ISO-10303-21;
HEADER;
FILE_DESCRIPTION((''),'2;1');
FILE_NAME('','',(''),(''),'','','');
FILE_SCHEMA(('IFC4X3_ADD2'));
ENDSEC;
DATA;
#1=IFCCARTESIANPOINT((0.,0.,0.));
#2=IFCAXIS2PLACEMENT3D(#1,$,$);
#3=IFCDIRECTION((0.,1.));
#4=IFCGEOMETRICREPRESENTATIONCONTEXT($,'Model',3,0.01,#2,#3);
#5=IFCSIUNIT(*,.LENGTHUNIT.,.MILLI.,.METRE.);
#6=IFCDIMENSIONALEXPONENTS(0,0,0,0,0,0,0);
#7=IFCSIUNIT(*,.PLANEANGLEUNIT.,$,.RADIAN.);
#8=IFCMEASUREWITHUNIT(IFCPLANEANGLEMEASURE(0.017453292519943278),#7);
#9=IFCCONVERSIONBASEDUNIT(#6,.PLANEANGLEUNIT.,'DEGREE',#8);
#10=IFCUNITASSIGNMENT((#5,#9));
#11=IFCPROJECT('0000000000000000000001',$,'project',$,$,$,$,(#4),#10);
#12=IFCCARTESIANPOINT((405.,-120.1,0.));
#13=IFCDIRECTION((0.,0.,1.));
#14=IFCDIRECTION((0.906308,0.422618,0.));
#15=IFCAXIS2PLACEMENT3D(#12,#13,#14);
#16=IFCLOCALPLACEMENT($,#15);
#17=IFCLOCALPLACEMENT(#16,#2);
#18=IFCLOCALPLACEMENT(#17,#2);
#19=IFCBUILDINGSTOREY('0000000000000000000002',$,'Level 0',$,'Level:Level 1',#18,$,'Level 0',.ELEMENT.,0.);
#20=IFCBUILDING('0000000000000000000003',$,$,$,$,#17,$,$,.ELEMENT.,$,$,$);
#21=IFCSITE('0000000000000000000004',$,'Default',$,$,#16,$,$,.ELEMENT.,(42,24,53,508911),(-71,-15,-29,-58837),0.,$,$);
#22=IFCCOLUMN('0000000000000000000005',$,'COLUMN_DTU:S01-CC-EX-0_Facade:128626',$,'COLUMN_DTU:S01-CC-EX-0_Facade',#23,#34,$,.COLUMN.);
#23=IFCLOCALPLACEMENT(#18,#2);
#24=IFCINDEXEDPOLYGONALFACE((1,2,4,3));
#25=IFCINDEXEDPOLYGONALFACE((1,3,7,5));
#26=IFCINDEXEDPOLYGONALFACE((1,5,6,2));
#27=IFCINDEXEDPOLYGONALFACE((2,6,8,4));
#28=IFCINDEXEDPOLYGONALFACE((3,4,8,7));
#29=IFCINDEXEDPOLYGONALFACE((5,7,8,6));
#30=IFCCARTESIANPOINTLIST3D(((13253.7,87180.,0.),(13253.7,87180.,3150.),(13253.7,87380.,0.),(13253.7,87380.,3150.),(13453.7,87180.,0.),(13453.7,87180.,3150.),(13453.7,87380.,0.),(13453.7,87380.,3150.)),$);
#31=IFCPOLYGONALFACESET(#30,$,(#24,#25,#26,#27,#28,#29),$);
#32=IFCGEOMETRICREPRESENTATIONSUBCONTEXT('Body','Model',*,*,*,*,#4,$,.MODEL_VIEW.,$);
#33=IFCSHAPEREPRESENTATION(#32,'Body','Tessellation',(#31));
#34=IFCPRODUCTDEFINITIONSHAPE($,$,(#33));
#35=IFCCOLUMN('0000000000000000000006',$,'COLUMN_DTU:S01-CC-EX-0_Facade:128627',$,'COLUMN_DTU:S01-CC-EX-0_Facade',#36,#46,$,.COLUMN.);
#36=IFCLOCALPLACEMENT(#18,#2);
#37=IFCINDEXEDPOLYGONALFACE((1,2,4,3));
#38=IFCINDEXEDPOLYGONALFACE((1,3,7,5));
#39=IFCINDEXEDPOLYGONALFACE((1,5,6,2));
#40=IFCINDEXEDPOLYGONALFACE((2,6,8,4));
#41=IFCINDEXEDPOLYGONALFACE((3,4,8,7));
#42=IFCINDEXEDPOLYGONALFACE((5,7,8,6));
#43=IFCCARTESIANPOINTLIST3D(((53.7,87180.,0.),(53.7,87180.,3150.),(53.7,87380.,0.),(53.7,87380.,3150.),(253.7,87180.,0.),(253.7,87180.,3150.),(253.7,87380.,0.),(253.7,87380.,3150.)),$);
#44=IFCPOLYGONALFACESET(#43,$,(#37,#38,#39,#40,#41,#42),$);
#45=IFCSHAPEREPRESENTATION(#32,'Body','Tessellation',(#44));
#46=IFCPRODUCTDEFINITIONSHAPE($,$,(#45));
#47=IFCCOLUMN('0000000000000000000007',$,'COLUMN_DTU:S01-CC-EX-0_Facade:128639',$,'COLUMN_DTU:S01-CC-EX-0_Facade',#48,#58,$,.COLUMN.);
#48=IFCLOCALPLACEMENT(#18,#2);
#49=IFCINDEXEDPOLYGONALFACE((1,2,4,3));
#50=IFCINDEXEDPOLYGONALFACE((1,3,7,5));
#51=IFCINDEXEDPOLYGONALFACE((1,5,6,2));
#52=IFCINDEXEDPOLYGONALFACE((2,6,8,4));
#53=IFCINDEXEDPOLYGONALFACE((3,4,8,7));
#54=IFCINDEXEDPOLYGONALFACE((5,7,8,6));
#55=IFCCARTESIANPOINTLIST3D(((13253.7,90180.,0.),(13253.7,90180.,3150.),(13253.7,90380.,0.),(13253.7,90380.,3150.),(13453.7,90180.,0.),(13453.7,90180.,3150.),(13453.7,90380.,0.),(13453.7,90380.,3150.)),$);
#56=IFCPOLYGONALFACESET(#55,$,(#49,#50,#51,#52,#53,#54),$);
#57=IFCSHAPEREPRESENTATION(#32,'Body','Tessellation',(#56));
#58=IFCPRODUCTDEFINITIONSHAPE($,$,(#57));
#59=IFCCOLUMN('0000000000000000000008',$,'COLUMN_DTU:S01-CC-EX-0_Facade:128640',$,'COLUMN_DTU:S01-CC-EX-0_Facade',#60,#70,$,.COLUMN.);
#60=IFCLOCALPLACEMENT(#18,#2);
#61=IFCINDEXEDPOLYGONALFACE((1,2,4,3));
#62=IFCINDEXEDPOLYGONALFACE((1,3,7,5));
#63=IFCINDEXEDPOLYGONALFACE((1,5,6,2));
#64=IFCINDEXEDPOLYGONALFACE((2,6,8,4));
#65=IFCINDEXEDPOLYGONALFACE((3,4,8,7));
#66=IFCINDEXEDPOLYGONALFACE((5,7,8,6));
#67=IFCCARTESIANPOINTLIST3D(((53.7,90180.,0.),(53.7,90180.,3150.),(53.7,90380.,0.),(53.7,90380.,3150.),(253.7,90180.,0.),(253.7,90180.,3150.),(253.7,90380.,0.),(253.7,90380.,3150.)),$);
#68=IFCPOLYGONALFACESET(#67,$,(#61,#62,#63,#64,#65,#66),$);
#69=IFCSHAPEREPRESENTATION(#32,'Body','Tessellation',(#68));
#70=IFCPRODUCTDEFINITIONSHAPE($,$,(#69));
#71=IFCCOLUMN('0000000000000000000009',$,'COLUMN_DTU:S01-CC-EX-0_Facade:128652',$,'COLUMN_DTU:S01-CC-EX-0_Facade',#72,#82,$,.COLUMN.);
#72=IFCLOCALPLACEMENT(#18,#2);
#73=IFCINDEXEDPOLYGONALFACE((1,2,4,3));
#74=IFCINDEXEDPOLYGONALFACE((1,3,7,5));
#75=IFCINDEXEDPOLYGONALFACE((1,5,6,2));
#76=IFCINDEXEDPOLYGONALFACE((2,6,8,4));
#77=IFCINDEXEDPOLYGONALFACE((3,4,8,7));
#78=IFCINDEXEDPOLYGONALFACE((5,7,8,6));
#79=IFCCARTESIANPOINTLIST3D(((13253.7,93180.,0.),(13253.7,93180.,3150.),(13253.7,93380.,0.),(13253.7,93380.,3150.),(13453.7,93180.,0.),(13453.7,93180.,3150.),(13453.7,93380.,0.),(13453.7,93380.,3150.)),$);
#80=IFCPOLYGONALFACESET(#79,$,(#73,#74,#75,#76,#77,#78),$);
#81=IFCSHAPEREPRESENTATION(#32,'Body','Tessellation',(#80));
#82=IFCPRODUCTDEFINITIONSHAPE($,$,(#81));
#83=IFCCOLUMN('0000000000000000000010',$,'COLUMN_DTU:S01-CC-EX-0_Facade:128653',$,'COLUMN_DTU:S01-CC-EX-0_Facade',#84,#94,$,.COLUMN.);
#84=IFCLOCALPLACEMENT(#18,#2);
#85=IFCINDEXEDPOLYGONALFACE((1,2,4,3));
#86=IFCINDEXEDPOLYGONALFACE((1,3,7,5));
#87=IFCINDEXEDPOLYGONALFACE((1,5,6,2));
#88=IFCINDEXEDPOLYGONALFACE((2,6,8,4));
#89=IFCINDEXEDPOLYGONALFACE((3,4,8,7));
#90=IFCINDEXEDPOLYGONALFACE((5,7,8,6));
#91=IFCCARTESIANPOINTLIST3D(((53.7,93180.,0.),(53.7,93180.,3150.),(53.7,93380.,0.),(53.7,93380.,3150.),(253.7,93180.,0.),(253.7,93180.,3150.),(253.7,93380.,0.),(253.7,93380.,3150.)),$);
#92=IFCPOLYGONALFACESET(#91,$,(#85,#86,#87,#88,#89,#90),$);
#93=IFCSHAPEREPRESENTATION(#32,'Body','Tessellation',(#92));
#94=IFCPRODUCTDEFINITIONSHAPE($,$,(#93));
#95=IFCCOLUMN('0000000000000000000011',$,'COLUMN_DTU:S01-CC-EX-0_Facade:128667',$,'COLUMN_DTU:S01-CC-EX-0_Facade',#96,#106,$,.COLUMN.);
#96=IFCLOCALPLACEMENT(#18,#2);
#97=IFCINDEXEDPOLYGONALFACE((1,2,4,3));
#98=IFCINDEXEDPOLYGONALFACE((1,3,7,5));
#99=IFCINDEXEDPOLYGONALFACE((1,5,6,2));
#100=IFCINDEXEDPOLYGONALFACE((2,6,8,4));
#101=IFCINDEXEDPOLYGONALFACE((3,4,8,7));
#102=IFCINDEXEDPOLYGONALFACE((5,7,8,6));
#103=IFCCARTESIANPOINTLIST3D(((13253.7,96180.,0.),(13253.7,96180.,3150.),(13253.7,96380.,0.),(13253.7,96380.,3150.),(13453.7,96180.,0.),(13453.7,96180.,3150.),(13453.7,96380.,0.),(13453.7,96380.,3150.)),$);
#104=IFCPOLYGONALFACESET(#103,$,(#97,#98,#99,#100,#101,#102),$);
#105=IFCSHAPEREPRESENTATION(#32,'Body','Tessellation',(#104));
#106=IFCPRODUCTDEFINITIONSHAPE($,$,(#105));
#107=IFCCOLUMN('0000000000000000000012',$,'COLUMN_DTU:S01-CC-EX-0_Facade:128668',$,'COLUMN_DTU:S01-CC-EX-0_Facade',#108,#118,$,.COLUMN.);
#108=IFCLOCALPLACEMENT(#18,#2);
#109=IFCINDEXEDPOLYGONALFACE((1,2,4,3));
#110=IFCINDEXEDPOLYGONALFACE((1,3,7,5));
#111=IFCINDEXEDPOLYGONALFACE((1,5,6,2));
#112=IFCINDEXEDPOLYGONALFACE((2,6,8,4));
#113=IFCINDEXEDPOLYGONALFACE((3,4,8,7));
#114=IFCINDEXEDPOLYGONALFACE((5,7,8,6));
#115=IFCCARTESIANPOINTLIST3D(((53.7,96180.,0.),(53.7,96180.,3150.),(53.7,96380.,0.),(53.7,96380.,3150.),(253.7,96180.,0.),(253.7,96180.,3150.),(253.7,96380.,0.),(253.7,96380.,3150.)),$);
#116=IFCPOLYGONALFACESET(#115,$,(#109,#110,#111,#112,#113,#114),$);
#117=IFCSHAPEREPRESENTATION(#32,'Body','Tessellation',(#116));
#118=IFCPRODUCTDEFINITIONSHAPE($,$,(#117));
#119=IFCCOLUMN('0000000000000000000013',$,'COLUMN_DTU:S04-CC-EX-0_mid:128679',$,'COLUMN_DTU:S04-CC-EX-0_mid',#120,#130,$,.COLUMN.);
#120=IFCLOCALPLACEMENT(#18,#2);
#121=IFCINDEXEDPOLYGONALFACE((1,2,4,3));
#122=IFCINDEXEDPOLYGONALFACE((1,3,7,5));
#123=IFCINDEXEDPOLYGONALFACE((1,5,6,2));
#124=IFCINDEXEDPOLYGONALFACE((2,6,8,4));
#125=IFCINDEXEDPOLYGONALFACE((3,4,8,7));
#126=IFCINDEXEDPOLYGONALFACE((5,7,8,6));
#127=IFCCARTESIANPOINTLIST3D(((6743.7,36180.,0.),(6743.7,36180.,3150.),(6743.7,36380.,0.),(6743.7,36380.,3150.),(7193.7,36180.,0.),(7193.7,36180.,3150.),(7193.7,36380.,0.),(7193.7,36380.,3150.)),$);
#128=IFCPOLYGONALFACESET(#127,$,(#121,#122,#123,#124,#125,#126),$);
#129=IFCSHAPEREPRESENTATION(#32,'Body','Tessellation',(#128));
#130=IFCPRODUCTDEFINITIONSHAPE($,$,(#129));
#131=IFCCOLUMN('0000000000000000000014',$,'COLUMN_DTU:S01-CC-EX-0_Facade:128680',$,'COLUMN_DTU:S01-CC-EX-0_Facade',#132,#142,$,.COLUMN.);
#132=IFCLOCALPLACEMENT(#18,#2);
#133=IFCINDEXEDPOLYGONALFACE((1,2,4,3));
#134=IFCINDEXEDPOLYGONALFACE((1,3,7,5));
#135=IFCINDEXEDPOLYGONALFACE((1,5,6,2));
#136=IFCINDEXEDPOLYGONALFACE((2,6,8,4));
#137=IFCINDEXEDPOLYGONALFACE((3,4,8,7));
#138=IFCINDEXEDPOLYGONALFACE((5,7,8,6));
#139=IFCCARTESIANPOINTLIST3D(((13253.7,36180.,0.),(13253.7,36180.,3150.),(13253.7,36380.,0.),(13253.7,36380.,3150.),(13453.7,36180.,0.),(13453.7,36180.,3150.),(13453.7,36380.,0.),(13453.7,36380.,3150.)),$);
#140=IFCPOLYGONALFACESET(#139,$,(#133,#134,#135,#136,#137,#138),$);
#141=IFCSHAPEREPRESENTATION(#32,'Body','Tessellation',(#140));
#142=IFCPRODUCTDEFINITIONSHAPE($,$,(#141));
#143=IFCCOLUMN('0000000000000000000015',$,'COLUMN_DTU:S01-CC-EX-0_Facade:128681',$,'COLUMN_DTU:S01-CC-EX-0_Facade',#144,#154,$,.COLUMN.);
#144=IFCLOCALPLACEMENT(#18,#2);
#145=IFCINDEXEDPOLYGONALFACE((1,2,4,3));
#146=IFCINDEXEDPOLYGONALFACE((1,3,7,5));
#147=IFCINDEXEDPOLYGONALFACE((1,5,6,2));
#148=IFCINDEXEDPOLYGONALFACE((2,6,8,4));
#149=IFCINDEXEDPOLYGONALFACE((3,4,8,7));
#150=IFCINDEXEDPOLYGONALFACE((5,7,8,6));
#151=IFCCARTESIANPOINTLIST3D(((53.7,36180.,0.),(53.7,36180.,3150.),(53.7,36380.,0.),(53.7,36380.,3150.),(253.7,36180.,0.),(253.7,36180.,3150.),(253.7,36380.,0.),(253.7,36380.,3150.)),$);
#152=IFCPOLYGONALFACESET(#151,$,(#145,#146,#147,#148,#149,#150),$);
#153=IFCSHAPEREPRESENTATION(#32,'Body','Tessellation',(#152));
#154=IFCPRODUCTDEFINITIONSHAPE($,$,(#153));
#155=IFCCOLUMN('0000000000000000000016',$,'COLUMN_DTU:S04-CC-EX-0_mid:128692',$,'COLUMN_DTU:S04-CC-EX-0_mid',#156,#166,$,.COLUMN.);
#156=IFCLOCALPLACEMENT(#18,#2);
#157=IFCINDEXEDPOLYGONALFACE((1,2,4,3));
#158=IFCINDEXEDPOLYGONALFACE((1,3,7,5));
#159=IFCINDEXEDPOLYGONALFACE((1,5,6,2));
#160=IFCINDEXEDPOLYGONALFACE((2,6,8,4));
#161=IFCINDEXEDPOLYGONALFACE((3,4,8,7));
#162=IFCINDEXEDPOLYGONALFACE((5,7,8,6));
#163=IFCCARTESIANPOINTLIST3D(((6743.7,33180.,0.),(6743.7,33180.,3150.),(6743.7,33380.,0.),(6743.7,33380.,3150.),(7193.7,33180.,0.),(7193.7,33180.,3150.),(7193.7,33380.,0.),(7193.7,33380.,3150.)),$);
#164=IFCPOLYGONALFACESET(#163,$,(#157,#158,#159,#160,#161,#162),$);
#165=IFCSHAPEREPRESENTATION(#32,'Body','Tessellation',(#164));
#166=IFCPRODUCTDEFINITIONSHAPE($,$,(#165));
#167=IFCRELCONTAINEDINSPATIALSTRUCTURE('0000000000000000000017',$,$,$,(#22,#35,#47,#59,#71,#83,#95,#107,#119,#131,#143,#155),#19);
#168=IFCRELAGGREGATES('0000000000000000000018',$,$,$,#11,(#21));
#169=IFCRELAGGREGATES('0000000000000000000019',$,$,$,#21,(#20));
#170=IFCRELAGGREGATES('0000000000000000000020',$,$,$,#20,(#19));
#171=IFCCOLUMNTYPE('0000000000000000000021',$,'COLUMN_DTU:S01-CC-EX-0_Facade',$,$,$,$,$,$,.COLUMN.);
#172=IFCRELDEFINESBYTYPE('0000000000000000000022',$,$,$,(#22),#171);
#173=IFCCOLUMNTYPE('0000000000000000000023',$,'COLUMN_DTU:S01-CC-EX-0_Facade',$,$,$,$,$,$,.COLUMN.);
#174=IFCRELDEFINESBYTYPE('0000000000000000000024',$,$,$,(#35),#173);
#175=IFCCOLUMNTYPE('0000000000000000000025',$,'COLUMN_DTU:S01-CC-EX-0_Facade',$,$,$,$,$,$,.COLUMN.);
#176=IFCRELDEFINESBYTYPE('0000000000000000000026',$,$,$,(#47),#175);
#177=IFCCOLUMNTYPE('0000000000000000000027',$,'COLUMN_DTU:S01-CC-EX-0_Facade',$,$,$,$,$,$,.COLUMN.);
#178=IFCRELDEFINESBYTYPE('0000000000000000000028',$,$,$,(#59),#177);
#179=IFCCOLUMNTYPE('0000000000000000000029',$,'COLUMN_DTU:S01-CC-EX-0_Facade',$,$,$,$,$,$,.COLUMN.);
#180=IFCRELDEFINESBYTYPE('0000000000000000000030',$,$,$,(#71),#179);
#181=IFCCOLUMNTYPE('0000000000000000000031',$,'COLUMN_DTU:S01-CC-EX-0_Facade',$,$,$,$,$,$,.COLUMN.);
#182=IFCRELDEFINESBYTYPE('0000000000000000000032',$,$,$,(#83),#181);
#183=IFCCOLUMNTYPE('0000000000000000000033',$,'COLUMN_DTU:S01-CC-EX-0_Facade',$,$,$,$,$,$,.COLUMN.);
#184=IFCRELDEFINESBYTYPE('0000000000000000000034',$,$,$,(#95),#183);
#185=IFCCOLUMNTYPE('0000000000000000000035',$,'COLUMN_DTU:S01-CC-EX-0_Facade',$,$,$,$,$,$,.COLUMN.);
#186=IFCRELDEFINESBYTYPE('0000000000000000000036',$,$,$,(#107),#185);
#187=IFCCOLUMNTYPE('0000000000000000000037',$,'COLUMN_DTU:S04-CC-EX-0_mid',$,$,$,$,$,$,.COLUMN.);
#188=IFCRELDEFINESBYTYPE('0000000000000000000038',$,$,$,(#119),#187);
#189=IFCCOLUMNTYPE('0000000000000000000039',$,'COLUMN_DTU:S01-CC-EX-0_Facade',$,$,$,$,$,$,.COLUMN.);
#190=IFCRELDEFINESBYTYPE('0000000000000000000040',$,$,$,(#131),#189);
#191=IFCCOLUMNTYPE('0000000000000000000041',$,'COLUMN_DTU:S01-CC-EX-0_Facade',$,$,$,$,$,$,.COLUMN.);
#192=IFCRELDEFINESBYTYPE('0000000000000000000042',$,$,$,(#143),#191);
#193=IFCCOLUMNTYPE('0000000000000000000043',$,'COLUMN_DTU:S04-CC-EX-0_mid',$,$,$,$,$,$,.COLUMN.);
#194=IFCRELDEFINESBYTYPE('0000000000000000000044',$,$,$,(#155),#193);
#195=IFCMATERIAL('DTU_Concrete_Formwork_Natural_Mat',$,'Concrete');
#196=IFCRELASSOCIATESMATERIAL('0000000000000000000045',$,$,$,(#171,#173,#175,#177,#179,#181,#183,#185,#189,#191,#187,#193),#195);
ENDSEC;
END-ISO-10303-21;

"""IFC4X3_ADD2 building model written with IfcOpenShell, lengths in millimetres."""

from ifc_helpers import new_model, entity, si_unit, converted_unit, direction, frame, frame_2d, origin, origin_2d_with_axis, place, context, subcontext, project, spatial, rectangle, extrude, source, transform, mapped, material, material_profile, profile_set, type_object, type_shapes, element, save


model = new_model("IFC4X3_ADD2")

# Units and contexts
model_context = context("Model", 3, precision=0.01, world=origin(), true_north=direction((0.0, 1.0)))
body_context = subcontext(model_context, "Body", "Model", "MODEL_VIEW")
ifc_project = project(units=[si_unit("LENGTHUNIT", "METRE", prefix="MILLI"), converted_unit("PLANEANGLEUNIT", "DEGREE", entity("IfcPlaneAngleMeasure", 0.017453292519943278), si_unit("PLANEANGLEUNIT", "RADIAN"), dimensions=[0, 0, 0, 0, 0, 0, 0])], contexts=[model_context])

# Site, building, storey
site_placement = place(None, frame((405.0, -120.1, 0.0), z_axis=(0.0, 0.0, 1.0), x_axis=(0.906308, 0.422618, 0.0)))
site = spatial("IfcSite", under=ifc_project, at=site_placement, Name="Default", CompositionType="ELEMENT", RefLatitude=(42, 24, 53, 508911), RefLongitude=(-71, -15, -29, -58837), RefElevation=0.0)
building_placement = place(site_placement, origin())
building = spatial("IfcBuilding", under=site, at=building_placement, CompositionType="ELEMENT")
storey_placement = place(building_placement, origin())
storey = spatial("IfcBuildingStorey", under=building, at=storey_placement, Name="Level 0", ObjectType="Level:Level 1", LongName="Level 0", CompositionType="ELEMENT", Elevation=0.0)

# Columns
ifc_material = material(Name="DTU_Concrete_Formwork_Natural_Mat", Category="Concrete")
ifc_material_profile_1 = material_profile(ifc_material, rectangle(XDim=200.0, YDim=200.0, at=frame_2d((0.0, 0.0), x_axis=(1.0, 0.0))), Name="S01-CC-EX-0_Facade")
ifc_profile_set_1 = profile_set([ifc_material_profile_1], Name="S01-CC-EX-0_Facade")
column_type_1 = type_object("IfcColumnType", Name="COLUMN_DTU:S01-CC-EX-0_Facade", PredefinedType="COLUMN", material=ifc_profile_set_1)
shared_shape_1 = source(origin(), body_context, "Body", "SweptSolid", [
    extrude(rectangle(XDim=200.0, YDim=200.0, at=frame_2d((0.0, 0.0), x_axis=(1.0, 0.0))), frame((13353.7, 87280.0, 0.0), z_axis=(0.0, 0.0, 1.0), x_axis=(0.0, 1.0, 0.0)), (0.0, 0.0, 1.0), 3150.0),
])
type_shapes(column_type_1, [shared_shape_1])
column_1_placement = place(storey_placement, origin())
element("IfcColumn", 1, at=column_1_placement, inside=storey, type_object=column_type_1, Name="COLUMN_DTU:S01-CC-EX-0_Facade:128626", ObjectType="COLUMN_DTU:S01-CC-EX-0_Facade", PredefinedType="COLUMN", context=body_context, shape_type="MappedRepresentation", body=[
    mapped(shared_shape_1, transform((0.0, 0.0, 0.0), scale=1.0)),
])
column_type_2 = type_object("IfcColumnType", Name="COLUMN_DTU:S01-CC-EX-0_Facade", PredefinedType="COLUMN", material=ifc_profile_set_1)
shared_shape_2 = source(origin(), body_context, "Body", "SweptSolid", [
    extrude(rectangle(XDim=200.0, YDim=200.0, at=frame_2d((0.0, 0.0), x_axis=(1.0, 0.0))), frame((153.7, 87280.0, 0.0), z_axis=(0.0, 0.0, 1.0), x_axis=(0.0, 1.0, 0.0)), (0.0, 0.0, 1.0), 3150.0),
])
type_shapes(column_type_2, [shared_shape_2])
column_2_placement = place(storey_placement, origin())
element("IfcColumn", 2, at=column_2_placement, inside=storey, type_object=column_type_2, Name="COLUMN_DTU:S01-CC-EX-0_Facade:128627", ObjectType="COLUMN_DTU:S01-CC-EX-0_Facade", PredefinedType="COLUMN", context=body_context, shape_type="MappedRepresentation", body=[
    mapped(shared_shape_2, transform((0.0, 0.0, 0.0), scale=1.0)),
])
column_type_3 = type_object("IfcColumnType", Name="COLUMN_DTU:S01-CC-EX-0_Facade", PredefinedType="COLUMN", material=ifc_profile_set_1)
shared_shape_3 = source(origin(), body_context, "Body", "SweptSolid", [
    extrude(rectangle(XDim=200.0, YDim=200.0, at=frame_2d((0.0, 0.0), x_axis=(1.0, 0.0))), frame((13353.7, 90280.0, 0.0), z_axis=(0.0, 0.0, 1.0), x_axis=(0.0, 1.0, 0.0)), (0.0, 0.0, 1.0), 3150.0),
])
type_shapes(column_type_3, [shared_shape_3])
column_3_placement = place(storey_placement, origin())
element("IfcColumn", 3, at=column_3_placement, inside=storey, type_object=column_type_3, Name="COLUMN_DTU:S01-CC-EX-0_Facade:128639", ObjectType="COLUMN_DTU:S01-CC-EX-0_Facade", PredefinedType="COLUMN", context=body_context, shape_type="MappedRepresentation", body=[
    mapped(shared_shape_3, transform((0.0, 0.0, 0.0), scale=1.0)),
])
column_type_4 = type_object("IfcColumnType", Name="COLUMN_DTU:S01-CC-EX-0_Facade", PredefinedType="COLUMN", material=ifc_profile_set_1)
shared_shape_4 = source(origin(), body_context, "Body", "SweptSolid", [
    extrude(rectangle(XDim=200.0, YDim=200.0, at=frame_2d((0.0, 0.0), x_axis=(1.0, 0.0))), frame((153.7, 90280.0, 0.0), z_axis=(0.0, 0.0, 1.0), x_axis=(0.0, 1.0, 0.0)), (0.0, 0.0, 1.0), 3150.0),
])
type_shapes(column_type_4, [shared_shape_4])
column_4_placement = place(storey_placement, origin())
element("IfcColumn", 4, at=column_4_placement, inside=storey, type_object=column_type_4, Name="COLUMN_DTU:S01-CC-EX-0_Facade:128640", ObjectType="COLUMN_DTU:S01-CC-EX-0_Facade", PredefinedType="COLUMN", context=body_context, shape_type="MappedRepresentation", body=[
    mapped(shared_shape_4, transform((0.0, 0.0, 0.0), scale=1.0)),
])
column_type_5 = type_object("IfcColumnType", Name="COLUMN_DTU:S01-CC-EX-0_Facade", PredefinedType="COLUMN", material=ifc_profile_set_1)
shared_shape_5 = source(origin(), body_context, "Body", "SweptSolid", [
    extrude(rectangle(XDim=200.0, YDim=200.0, at=frame_2d((0.0, 0.0), x_axis=(1.0, 0.0))), frame((13353.7, 93280.0, 0.0), z_axis=(0.0, 0.0, 1.0), x_axis=(0.0, 1.0, 0.0)), (0.0, 0.0, 1.0), 3150.0),
])
type_shapes(column_type_5, [shared_shape_5])
column_5_placement = place(storey_placement, origin())
element("IfcColumn", 5, at=column_5_placement, inside=storey, type_object=column_type_5, Name="COLUMN_DTU:S01-CC-EX-0_Facade:128652", ObjectType="COLUMN_DTU:S01-CC-EX-0_Facade", PredefinedType="COLUMN", context=body_context, shape_type="MappedRepresentation", body=[
    mapped(shared_shape_5, transform((0.0, 0.0, 0.0), scale=1.0)),
])
column_type_6 = type_object("IfcColumnType", Name="COLUMN_DTU:S01-CC-EX-0_Facade", PredefinedType="COLUMN", material=ifc_profile_set_1)
shared_shape_6 = source(origin(), body_context, "Body", "SweptSolid", [
    extrude(rectangle(XDim=200.0, YDim=200.0, at=frame_2d((0.0, 0.0), x_axis=(1.0, 0.0))), frame((153.7, 93280.0, 0.0), z_axis=(0.0, 0.0, 1.0), x_axis=(0.0, 1.0, 0.0)), (0.0, 0.0, 1.0), 3150.0),
])
type_shapes(column_type_6, [shared_shape_6])
column_6_placement = place(storey_placement, origin())
element("IfcColumn", 6, at=column_6_placement, inside=storey, type_object=column_type_6, Name="COLUMN_DTU:S01-CC-EX-0_Facade:128653", ObjectType="COLUMN_DTU:S01-CC-EX-0_Facade", PredefinedType="COLUMN", context=body_context, shape_type="MappedRepresentation", body=[
    mapped(shared_shape_6, transform((0.0, 0.0, 0.0), scale=1.0)),
])
column_type_7 = type_object("IfcColumnType", Name="COLUMN_DTU:S01-CC-EX-0_Facade", PredefinedType="COLUMN", material=ifc_profile_set_1)
shared_shape_7 = source(origin(), body_context, "Body", "SweptSolid", [
    extrude(rectangle(XDim=200.0, YDim=200.0, at=frame_2d((0.0, 0.0), x_axis=(1.0, 0.0))), frame((13353.7, 96280.0, 0.0), z_axis=(0.0, 0.0, 1.0), x_axis=(0.0, 1.0, 0.0)), (0.0, 0.0, 1.0), 3150.0),
])
type_shapes(column_type_7, [shared_shape_7])
column_7_placement = place(storey_placement, origin())
element("IfcColumn", 7, at=column_7_placement, inside=storey, type_object=column_type_7, Name="COLUMN_DTU:S01-CC-EX-0_Facade:128667", ObjectType="COLUMN_DTU:S01-CC-EX-0_Facade", PredefinedType="COLUMN", context=body_context, shape_type="MappedRepresentation", body=[
    mapped(shared_shape_7, transform((0.0, 0.0, 0.0), scale=1.0)),
])
column_type_8 = type_object("IfcColumnType", Name="COLUMN_DTU:S01-CC-EX-0_Facade", PredefinedType="COLUMN", material=ifc_profile_set_1)
shared_shape_8 = source(origin(), body_context, "Body", "SweptSolid", [
    extrude(rectangle(XDim=200.0, YDim=200.0, at=frame_2d((0.0, 0.0), x_axis=(1.0, 0.0))), frame((153.7, 96280.0, 0.0), z_axis=(0.0, 0.0, 1.0), x_axis=(0.0, 1.0, 0.0)), (0.0, 0.0, 1.0), 3150.0),
])
type_shapes(column_type_8, [shared_shape_8])
column_8_placement = place(storey_placement, origin())
element("IfcColumn", 8, at=column_8_placement, inside=storey, type_object=column_type_8, Name="COLUMN_DTU:S01-CC-EX-0_Facade:128668", ObjectType="COLUMN_DTU:S01-CC-EX-0_Facade", PredefinedType="COLUMN", context=body_context, shape_type="MappedRepresentation", body=[
    mapped(shared_shape_8, transform((0.0, 0.0, 0.0), scale=1.0)),
])
ifc_material_profile_2 = material_profile(ifc_material, rectangle(XDim=200.0, YDim=450.0, at=frame_2d((0.0, 0.0), x_axis=(1.0, 0.0))), Name="S04-CC-EX-0_mid")
ifc_profile_set_2 = profile_set([ifc_material_profile_2], Name="S04-CC-EX-0_mid")
column_type_9 = type_object("IfcColumnType", Name="COLUMN_DTU:S04-CC-EX-0_mid", PredefinedType="COLUMN", material=ifc_profile_set_2)
shared_shape_9 = source(origin(), body_context, "Body", "SweptSolid", [
    extrude(rectangle(XDim=200.0, YDim=450.0, at=frame_2d((0.0, 0.0), x_axis=(1.0, 0.0))), frame((6968.7, 36280.0, 0.0), z_axis=(0.0, 0.0, 1.0), x_axis=(0.0, 1.0, 0.0)), (0.0, 0.0, 1.0), 3150.0),
])
type_shapes(column_type_9, [shared_shape_9])
column_9_placement = place(storey_placement, origin())
element("IfcColumn", 9, at=column_9_placement, inside=storey, type_object=column_type_9, Name="COLUMN_DTU:S04-CC-EX-0_mid:128679", ObjectType="COLUMN_DTU:S04-CC-EX-0_mid", PredefinedType="COLUMN", context=body_context, shape_type="MappedRepresentation", body=[
    mapped(shared_shape_9, transform((0.0, 0.0, 0.0), scale=1.0)),
])
column_type_10 = type_object("IfcColumnType", Name="COLUMN_DTU:S01-CC-EX-0_Facade", PredefinedType="COLUMN", material=ifc_profile_set_1)
shared_shape_10 = source(origin(), body_context, "Body", "SweptSolid", [
    extrude(rectangle(XDim=200.0, YDim=200.0, at=frame_2d((0.0, 0.0), x_axis=(1.0, 0.0))), frame((13353.7, 36280.0, 0.0), z_axis=(0.0, 0.0, 1.0), x_axis=(0.0, 1.0, 0.0)), (0.0, 0.0, 1.0), 3150.0),
])
type_shapes(column_type_10, [shared_shape_10])
column_10_placement = place(storey_placement, origin())
element("IfcColumn", 10, at=column_10_placement, inside=storey, type_object=column_type_10, Name="COLUMN_DTU:S01-CC-EX-0_Facade:128680", ObjectType="COLUMN_DTU:S01-CC-EX-0_Facade", PredefinedType="COLUMN", context=body_context, shape_type="MappedRepresentation", body=[
    mapped(shared_shape_10, transform((0.0, 0.0, 0.0), scale=1.0)),
])
column_type_11 = type_object("IfcColumnType", Name="COLUMN_DTU:S01-CC-EX-0_Facade", PredefinedType="COLUMN", material=ifc_profile_set_1)
shared_shape_11 = source(origin(), body_context, "Body", "SweptSolid", [
    extrude(rectangle(XDim=200.0, YDim=200.0, at=frame_2d((0.0, 0.0), x_axis=(1.0, 0.0))), frame((153.7, 36280.0, 0.0), z_axis=(0.0, 0.0, 1.0), x_axis=(0.0, 1.0, 0.0)), (0.0, 0.0, 1.0), 3150.0),
])
type_shapes(column_type_11, [shared_shape_11])
column_11_placement = place(storey_placement, origin())
element("IfcColumn", 11, at=column_11_placement, inside=storey, type_object=column_type_11, Name="COLUMN_DTU:S01-CC-EX-0_Facade:128681", ObjectType="COLUMN_DTU:S01-CC-EX-0_Facade", PredefinedType="COLUMN", context=body_context, shape_type="MappedRepresentation", body=[
    mapped(shared_shape_11, transform((0.0, 0.0, 0.0), scale=1.0)),
])
column_type_12 = type_object("IfcColumnType", Name="COLUMN_DTU:S04-CC-EX-0_mid", PredefinedType="COLUMN", material=ifc_profile_set_2)
shared_shape_12 = source(origin(), body_context, "Body", "SweptSolid", [
    extrude(rectangle(XDim=200.0, YDim=450.0, at=origin_2d_with_axis()), frame((6968.7, 33280.0, 0.0), z_axis=(0.0, 0.0, 1.0), x_axis=(0.0, 1.0, 0.0)), (0.0, 0.0, 1.0), 3150.0),
])
type_shapes(column_type_12, [shared_shape_12])
column_12_placement = place(storey_placement, origin())
element("IfcColumn", 12, at=column_12_placement, inside=storey, type_object=column_type_12, Name="COLUMN_DTU:S04-CC-EX-0_mid:128692", ObjectType="COLUMN_DTU:S04-CC-EX-0_mid", PredefinedType="COLUMN", context=body_context, shape_type="MappedRepresentation", body=[
    mapped(shared_shape_12, transform((0.0, 0.0, 0.0), scale=1.0)),
])

save(model, "model.ifc")
